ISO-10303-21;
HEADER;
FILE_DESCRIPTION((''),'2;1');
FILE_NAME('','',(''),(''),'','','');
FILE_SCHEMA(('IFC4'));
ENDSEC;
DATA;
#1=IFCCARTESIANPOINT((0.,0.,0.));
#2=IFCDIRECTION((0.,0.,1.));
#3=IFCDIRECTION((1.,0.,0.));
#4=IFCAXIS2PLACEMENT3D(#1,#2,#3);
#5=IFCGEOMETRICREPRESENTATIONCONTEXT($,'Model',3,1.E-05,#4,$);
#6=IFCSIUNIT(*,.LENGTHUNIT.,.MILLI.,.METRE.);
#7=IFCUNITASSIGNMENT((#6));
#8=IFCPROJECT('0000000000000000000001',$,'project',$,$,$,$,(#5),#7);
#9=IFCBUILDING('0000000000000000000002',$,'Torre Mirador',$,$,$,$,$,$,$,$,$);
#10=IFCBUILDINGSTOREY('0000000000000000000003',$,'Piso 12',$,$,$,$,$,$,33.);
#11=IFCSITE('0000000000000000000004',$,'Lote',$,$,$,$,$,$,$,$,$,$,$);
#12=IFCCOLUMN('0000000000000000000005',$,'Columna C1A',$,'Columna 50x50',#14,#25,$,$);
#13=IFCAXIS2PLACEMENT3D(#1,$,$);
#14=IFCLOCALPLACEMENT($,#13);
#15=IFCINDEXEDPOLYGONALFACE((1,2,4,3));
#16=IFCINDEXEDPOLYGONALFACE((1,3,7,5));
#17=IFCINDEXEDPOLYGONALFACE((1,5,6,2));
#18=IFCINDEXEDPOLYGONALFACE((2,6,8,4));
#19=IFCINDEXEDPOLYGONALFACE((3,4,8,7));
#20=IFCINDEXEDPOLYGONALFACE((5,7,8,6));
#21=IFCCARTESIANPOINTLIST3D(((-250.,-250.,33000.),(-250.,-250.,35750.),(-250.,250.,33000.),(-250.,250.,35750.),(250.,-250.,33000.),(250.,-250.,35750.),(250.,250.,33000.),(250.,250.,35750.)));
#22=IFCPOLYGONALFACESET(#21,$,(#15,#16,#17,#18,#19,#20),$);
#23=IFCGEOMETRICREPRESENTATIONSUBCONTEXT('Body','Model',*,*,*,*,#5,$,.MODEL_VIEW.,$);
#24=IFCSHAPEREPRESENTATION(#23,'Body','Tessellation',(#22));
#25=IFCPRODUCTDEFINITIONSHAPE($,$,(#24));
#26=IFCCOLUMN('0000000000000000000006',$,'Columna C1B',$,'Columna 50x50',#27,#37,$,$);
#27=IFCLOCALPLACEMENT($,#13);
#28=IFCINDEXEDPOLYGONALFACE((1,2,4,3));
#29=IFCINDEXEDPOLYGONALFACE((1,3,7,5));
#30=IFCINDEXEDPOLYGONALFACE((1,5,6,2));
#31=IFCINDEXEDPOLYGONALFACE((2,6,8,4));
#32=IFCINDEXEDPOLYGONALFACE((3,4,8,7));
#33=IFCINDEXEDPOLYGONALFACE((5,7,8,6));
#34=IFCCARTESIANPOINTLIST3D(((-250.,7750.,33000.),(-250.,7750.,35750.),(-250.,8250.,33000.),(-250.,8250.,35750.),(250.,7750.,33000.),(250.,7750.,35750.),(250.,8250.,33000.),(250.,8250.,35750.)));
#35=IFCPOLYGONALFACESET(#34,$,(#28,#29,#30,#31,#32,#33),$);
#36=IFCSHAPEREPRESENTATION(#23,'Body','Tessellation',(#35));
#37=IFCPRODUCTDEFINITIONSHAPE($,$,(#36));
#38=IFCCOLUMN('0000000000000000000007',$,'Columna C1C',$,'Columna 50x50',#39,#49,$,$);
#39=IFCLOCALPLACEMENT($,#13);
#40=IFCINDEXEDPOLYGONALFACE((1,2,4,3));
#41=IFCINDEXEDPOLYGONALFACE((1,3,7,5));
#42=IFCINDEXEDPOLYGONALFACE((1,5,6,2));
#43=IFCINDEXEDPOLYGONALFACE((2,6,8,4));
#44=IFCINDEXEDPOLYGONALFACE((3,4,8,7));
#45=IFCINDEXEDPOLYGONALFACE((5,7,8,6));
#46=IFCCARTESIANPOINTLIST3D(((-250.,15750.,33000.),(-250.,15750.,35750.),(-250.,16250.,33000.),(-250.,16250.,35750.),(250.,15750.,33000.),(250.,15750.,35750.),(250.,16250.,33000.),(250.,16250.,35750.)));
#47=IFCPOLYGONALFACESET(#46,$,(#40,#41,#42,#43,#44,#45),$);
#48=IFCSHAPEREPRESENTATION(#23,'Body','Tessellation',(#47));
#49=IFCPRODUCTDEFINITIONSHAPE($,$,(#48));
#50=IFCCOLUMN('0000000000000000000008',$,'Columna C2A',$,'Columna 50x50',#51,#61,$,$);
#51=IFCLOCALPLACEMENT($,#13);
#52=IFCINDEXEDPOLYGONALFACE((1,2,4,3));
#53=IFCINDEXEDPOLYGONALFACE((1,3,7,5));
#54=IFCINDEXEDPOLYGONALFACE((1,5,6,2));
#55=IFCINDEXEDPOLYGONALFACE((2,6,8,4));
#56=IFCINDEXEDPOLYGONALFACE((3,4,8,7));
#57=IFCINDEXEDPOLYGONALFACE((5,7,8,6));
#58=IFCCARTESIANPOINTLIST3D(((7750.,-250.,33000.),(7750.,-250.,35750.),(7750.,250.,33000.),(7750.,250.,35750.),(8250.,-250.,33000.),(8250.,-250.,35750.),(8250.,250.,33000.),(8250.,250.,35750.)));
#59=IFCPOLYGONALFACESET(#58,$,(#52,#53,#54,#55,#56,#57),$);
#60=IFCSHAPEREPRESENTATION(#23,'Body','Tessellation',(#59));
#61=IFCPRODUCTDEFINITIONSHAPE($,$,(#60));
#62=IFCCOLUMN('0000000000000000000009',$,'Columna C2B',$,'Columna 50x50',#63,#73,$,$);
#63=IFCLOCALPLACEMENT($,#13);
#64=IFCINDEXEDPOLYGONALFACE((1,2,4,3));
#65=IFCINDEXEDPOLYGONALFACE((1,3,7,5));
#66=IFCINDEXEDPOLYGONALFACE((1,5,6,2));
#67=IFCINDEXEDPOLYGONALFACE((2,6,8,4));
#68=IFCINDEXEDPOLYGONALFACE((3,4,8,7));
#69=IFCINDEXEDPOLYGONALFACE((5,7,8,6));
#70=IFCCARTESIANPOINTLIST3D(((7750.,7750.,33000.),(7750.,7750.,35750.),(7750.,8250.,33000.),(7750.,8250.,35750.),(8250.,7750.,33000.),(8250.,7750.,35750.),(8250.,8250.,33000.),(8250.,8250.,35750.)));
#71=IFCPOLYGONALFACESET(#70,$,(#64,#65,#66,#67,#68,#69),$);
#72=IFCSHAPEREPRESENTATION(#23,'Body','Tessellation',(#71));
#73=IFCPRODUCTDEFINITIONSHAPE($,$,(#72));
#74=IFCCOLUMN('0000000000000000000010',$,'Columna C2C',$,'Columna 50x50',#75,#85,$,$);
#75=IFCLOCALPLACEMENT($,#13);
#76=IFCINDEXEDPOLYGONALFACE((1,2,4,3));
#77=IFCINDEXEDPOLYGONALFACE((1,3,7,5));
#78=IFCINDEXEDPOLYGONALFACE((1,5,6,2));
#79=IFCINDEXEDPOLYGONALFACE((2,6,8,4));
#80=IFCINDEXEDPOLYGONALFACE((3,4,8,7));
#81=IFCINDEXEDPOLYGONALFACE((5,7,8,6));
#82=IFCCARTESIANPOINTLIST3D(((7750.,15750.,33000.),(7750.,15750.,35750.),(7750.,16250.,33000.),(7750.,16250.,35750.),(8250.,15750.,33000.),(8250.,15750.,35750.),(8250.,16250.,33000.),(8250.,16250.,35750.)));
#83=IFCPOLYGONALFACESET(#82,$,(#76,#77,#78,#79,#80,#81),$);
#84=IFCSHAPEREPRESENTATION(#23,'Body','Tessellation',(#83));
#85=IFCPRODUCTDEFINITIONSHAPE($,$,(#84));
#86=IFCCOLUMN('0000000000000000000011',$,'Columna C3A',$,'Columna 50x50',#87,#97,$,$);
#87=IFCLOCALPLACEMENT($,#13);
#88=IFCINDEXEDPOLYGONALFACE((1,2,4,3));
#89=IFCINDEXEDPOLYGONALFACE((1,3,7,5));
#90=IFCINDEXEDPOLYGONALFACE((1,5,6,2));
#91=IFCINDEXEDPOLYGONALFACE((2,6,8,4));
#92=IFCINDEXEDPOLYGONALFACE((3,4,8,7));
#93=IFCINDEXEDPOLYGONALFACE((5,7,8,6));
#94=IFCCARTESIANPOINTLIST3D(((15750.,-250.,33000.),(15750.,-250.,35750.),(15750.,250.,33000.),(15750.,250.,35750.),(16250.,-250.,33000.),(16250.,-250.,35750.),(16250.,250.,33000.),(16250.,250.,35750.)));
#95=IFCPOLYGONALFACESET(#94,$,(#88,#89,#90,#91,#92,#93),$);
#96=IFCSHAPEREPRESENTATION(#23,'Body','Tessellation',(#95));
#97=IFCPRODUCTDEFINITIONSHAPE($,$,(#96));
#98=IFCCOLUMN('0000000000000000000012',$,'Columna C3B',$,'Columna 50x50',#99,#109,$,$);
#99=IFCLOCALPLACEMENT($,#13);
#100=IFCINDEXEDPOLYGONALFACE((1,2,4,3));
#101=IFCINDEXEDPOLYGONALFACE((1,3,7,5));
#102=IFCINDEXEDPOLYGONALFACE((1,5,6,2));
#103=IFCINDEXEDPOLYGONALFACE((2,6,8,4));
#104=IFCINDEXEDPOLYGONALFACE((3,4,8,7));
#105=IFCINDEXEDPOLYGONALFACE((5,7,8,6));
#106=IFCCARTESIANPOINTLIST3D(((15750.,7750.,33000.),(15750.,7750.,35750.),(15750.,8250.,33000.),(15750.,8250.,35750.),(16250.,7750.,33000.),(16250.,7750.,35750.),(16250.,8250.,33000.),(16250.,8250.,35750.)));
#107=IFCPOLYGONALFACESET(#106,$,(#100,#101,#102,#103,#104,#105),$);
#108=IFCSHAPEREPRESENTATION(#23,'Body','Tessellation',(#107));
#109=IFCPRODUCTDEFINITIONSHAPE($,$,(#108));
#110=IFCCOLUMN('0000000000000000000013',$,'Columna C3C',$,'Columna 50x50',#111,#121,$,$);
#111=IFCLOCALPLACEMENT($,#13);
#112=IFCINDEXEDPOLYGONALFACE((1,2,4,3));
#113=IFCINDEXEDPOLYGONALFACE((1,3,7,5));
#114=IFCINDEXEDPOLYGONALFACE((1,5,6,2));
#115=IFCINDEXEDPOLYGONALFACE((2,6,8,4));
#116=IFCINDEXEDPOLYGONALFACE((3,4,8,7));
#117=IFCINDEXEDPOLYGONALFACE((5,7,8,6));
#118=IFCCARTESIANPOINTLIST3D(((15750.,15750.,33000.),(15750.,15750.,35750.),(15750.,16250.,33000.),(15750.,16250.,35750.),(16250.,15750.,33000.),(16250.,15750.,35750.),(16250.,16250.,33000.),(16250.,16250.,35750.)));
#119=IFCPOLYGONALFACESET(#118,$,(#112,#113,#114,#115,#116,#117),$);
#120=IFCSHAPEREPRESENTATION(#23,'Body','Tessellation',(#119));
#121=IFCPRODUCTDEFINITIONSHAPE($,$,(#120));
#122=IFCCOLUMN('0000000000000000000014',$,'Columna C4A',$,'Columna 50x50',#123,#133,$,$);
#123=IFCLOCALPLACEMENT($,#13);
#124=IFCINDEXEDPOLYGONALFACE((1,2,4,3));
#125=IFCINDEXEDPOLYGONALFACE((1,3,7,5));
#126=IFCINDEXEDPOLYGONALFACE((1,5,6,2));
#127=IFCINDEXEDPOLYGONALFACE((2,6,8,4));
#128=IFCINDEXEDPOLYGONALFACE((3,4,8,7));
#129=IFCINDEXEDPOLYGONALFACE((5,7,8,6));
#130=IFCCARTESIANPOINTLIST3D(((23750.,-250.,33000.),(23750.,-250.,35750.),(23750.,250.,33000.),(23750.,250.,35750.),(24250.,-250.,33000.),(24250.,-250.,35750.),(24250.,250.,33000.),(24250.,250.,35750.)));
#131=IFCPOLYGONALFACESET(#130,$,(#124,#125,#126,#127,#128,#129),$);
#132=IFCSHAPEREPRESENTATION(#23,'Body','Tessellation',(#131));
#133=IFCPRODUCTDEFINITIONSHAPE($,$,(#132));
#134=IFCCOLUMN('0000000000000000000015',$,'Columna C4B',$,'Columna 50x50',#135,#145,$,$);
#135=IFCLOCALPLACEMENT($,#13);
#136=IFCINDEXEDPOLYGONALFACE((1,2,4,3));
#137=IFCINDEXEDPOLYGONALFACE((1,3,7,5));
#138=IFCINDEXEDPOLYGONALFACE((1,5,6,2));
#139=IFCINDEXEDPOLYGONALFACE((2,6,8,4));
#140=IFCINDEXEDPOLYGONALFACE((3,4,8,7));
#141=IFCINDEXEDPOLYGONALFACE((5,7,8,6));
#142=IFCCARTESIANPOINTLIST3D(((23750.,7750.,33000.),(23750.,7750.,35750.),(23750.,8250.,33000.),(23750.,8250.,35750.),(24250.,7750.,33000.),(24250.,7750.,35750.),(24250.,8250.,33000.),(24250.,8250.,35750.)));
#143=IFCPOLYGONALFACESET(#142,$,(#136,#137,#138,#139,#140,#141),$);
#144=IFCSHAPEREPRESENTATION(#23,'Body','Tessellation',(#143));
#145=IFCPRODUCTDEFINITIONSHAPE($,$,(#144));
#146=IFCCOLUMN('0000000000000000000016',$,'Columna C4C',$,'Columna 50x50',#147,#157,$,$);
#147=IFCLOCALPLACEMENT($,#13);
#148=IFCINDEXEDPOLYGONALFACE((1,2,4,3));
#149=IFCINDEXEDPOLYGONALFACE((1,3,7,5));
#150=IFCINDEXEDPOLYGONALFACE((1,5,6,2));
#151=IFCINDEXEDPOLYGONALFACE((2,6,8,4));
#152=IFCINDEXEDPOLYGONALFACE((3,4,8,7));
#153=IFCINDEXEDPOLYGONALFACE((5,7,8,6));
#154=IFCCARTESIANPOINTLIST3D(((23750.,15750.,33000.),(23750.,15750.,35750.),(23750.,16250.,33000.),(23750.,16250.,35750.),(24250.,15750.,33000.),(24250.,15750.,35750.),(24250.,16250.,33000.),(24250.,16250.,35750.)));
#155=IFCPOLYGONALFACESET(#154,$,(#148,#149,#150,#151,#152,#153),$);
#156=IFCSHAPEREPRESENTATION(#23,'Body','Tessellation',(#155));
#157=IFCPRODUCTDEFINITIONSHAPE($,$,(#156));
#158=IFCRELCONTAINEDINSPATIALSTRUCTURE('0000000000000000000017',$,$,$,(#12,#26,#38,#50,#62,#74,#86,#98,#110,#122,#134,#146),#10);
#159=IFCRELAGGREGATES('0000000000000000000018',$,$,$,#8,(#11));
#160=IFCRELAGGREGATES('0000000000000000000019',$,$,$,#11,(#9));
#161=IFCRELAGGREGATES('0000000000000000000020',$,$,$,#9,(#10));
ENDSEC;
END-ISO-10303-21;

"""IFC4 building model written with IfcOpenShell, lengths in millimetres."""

from ifc_helpers import new_model, si_unit, frame, origin_with_axes, place, context, subcontext, project, spatial, indexed_curve, outline, extrude, element, save


model = new_model("IFC4")

# Units and contexts
model_context = context("Model", 3, precision=1e-05, world=origin_with_axes())
body_context = subcontext(model_context, "Body", "Model", "MODEL_VIEW")
ifc_project = project(units=[si_unit("LENGTHUNIT", "METRE", prefix="MILLI")], contexts=[model_context])

# Site, building, storey
site = spatial("IfcSite", under=ifc_project, Name="Lote")
building = spatial("IfcBuilding", under=site, Name="Torre Mirador")
storey = spatial("IfcBuildingStorey", under=building, Name="Piso 12", Elevation=33.0)

# Columns
for number, where, z_axis, x_axis, name in (
    (1, (-250.0, -250.0, 33000.0), (0.0, 0.0, 1.0), (1.0, 0.0, 0.0), "Columna C1A"),
    (2, (-250.0, 7750.0, 33000.0), (0.0, 0.0, 1.0), (1.0, 0.0, 0.0), "Columna C1B"),
    (3, (-250.0, 15750.0, 33000.0), (0.0, 0.0, 1.0), (1.0, 0.0, 0.0), "Columna C1C"),
    (4, (7750.0, -250.0, 33000.0), (0.0, 0.0, 1.0), (1.0, 0.0, 0.0), "Columna C2A"),
    (5, (7750.0, 7750.0, 33000.0), (0.0, 0.0, 1.0), (1.0, 0.0, 0.0), "Columna C2B"),
    (6, (7750.0, 15750.0, 33000.0), (0.0, 0.0, 1.0), (1.0, 0.0, 0.0), "Columna C2C"),
    (7, (15750.0, -250.0, 33000.0), (0.0, 0.0, 1.0), (1.0, 0.0, 0.0), "Columna C3A"),
    (8, (15750.0, 7750.0, 33000.0), (0.0, 0.0, 1.0), (1.0, 0.0, 0.0), "Columna C3B"),
    (9, (15750.0, 15750.0, 33000.0), (0.0, 0.0, 1.0), (1.0, 0.0, 0.0), "Columna C3C"),
    (10, (23750.0, -250.0, 33000.0), (0.0, 0.0, 1.0), (1.0, 0.0, 0.0), "Columna C4A"),
    (11, (23750.0, 7750.0, 33000.0), (0.0, 0.0, 1.0), (1.0, 0.0, 0.0), "Columna C4B"),
    (12, (23750.0, 15750.0, 33000.0), (0.0, 0.0, 1.0), (1.0, 0.0, 0.0), "Columna C4C"),
):
    element("IfcColumn", number, at=place(None, frame(where, z_axis=z_axis, x_axis=x_axis)), inside=storey, Name=name, ObjectType="Columna 50x50", context=body_context, shape_type="SweptSolid", body=[
        extrude(outline(indexed_curve([(0.0, 0.0), (0.0, 500.0), (500.0, 500.0), (500.0, 0.0), (0.0, 0.0)], self_intersect=False)), origin_with_axes(), (0.0, 0.0, 1.0), 2750.0),
    ])

save(model, "model.ifc")
